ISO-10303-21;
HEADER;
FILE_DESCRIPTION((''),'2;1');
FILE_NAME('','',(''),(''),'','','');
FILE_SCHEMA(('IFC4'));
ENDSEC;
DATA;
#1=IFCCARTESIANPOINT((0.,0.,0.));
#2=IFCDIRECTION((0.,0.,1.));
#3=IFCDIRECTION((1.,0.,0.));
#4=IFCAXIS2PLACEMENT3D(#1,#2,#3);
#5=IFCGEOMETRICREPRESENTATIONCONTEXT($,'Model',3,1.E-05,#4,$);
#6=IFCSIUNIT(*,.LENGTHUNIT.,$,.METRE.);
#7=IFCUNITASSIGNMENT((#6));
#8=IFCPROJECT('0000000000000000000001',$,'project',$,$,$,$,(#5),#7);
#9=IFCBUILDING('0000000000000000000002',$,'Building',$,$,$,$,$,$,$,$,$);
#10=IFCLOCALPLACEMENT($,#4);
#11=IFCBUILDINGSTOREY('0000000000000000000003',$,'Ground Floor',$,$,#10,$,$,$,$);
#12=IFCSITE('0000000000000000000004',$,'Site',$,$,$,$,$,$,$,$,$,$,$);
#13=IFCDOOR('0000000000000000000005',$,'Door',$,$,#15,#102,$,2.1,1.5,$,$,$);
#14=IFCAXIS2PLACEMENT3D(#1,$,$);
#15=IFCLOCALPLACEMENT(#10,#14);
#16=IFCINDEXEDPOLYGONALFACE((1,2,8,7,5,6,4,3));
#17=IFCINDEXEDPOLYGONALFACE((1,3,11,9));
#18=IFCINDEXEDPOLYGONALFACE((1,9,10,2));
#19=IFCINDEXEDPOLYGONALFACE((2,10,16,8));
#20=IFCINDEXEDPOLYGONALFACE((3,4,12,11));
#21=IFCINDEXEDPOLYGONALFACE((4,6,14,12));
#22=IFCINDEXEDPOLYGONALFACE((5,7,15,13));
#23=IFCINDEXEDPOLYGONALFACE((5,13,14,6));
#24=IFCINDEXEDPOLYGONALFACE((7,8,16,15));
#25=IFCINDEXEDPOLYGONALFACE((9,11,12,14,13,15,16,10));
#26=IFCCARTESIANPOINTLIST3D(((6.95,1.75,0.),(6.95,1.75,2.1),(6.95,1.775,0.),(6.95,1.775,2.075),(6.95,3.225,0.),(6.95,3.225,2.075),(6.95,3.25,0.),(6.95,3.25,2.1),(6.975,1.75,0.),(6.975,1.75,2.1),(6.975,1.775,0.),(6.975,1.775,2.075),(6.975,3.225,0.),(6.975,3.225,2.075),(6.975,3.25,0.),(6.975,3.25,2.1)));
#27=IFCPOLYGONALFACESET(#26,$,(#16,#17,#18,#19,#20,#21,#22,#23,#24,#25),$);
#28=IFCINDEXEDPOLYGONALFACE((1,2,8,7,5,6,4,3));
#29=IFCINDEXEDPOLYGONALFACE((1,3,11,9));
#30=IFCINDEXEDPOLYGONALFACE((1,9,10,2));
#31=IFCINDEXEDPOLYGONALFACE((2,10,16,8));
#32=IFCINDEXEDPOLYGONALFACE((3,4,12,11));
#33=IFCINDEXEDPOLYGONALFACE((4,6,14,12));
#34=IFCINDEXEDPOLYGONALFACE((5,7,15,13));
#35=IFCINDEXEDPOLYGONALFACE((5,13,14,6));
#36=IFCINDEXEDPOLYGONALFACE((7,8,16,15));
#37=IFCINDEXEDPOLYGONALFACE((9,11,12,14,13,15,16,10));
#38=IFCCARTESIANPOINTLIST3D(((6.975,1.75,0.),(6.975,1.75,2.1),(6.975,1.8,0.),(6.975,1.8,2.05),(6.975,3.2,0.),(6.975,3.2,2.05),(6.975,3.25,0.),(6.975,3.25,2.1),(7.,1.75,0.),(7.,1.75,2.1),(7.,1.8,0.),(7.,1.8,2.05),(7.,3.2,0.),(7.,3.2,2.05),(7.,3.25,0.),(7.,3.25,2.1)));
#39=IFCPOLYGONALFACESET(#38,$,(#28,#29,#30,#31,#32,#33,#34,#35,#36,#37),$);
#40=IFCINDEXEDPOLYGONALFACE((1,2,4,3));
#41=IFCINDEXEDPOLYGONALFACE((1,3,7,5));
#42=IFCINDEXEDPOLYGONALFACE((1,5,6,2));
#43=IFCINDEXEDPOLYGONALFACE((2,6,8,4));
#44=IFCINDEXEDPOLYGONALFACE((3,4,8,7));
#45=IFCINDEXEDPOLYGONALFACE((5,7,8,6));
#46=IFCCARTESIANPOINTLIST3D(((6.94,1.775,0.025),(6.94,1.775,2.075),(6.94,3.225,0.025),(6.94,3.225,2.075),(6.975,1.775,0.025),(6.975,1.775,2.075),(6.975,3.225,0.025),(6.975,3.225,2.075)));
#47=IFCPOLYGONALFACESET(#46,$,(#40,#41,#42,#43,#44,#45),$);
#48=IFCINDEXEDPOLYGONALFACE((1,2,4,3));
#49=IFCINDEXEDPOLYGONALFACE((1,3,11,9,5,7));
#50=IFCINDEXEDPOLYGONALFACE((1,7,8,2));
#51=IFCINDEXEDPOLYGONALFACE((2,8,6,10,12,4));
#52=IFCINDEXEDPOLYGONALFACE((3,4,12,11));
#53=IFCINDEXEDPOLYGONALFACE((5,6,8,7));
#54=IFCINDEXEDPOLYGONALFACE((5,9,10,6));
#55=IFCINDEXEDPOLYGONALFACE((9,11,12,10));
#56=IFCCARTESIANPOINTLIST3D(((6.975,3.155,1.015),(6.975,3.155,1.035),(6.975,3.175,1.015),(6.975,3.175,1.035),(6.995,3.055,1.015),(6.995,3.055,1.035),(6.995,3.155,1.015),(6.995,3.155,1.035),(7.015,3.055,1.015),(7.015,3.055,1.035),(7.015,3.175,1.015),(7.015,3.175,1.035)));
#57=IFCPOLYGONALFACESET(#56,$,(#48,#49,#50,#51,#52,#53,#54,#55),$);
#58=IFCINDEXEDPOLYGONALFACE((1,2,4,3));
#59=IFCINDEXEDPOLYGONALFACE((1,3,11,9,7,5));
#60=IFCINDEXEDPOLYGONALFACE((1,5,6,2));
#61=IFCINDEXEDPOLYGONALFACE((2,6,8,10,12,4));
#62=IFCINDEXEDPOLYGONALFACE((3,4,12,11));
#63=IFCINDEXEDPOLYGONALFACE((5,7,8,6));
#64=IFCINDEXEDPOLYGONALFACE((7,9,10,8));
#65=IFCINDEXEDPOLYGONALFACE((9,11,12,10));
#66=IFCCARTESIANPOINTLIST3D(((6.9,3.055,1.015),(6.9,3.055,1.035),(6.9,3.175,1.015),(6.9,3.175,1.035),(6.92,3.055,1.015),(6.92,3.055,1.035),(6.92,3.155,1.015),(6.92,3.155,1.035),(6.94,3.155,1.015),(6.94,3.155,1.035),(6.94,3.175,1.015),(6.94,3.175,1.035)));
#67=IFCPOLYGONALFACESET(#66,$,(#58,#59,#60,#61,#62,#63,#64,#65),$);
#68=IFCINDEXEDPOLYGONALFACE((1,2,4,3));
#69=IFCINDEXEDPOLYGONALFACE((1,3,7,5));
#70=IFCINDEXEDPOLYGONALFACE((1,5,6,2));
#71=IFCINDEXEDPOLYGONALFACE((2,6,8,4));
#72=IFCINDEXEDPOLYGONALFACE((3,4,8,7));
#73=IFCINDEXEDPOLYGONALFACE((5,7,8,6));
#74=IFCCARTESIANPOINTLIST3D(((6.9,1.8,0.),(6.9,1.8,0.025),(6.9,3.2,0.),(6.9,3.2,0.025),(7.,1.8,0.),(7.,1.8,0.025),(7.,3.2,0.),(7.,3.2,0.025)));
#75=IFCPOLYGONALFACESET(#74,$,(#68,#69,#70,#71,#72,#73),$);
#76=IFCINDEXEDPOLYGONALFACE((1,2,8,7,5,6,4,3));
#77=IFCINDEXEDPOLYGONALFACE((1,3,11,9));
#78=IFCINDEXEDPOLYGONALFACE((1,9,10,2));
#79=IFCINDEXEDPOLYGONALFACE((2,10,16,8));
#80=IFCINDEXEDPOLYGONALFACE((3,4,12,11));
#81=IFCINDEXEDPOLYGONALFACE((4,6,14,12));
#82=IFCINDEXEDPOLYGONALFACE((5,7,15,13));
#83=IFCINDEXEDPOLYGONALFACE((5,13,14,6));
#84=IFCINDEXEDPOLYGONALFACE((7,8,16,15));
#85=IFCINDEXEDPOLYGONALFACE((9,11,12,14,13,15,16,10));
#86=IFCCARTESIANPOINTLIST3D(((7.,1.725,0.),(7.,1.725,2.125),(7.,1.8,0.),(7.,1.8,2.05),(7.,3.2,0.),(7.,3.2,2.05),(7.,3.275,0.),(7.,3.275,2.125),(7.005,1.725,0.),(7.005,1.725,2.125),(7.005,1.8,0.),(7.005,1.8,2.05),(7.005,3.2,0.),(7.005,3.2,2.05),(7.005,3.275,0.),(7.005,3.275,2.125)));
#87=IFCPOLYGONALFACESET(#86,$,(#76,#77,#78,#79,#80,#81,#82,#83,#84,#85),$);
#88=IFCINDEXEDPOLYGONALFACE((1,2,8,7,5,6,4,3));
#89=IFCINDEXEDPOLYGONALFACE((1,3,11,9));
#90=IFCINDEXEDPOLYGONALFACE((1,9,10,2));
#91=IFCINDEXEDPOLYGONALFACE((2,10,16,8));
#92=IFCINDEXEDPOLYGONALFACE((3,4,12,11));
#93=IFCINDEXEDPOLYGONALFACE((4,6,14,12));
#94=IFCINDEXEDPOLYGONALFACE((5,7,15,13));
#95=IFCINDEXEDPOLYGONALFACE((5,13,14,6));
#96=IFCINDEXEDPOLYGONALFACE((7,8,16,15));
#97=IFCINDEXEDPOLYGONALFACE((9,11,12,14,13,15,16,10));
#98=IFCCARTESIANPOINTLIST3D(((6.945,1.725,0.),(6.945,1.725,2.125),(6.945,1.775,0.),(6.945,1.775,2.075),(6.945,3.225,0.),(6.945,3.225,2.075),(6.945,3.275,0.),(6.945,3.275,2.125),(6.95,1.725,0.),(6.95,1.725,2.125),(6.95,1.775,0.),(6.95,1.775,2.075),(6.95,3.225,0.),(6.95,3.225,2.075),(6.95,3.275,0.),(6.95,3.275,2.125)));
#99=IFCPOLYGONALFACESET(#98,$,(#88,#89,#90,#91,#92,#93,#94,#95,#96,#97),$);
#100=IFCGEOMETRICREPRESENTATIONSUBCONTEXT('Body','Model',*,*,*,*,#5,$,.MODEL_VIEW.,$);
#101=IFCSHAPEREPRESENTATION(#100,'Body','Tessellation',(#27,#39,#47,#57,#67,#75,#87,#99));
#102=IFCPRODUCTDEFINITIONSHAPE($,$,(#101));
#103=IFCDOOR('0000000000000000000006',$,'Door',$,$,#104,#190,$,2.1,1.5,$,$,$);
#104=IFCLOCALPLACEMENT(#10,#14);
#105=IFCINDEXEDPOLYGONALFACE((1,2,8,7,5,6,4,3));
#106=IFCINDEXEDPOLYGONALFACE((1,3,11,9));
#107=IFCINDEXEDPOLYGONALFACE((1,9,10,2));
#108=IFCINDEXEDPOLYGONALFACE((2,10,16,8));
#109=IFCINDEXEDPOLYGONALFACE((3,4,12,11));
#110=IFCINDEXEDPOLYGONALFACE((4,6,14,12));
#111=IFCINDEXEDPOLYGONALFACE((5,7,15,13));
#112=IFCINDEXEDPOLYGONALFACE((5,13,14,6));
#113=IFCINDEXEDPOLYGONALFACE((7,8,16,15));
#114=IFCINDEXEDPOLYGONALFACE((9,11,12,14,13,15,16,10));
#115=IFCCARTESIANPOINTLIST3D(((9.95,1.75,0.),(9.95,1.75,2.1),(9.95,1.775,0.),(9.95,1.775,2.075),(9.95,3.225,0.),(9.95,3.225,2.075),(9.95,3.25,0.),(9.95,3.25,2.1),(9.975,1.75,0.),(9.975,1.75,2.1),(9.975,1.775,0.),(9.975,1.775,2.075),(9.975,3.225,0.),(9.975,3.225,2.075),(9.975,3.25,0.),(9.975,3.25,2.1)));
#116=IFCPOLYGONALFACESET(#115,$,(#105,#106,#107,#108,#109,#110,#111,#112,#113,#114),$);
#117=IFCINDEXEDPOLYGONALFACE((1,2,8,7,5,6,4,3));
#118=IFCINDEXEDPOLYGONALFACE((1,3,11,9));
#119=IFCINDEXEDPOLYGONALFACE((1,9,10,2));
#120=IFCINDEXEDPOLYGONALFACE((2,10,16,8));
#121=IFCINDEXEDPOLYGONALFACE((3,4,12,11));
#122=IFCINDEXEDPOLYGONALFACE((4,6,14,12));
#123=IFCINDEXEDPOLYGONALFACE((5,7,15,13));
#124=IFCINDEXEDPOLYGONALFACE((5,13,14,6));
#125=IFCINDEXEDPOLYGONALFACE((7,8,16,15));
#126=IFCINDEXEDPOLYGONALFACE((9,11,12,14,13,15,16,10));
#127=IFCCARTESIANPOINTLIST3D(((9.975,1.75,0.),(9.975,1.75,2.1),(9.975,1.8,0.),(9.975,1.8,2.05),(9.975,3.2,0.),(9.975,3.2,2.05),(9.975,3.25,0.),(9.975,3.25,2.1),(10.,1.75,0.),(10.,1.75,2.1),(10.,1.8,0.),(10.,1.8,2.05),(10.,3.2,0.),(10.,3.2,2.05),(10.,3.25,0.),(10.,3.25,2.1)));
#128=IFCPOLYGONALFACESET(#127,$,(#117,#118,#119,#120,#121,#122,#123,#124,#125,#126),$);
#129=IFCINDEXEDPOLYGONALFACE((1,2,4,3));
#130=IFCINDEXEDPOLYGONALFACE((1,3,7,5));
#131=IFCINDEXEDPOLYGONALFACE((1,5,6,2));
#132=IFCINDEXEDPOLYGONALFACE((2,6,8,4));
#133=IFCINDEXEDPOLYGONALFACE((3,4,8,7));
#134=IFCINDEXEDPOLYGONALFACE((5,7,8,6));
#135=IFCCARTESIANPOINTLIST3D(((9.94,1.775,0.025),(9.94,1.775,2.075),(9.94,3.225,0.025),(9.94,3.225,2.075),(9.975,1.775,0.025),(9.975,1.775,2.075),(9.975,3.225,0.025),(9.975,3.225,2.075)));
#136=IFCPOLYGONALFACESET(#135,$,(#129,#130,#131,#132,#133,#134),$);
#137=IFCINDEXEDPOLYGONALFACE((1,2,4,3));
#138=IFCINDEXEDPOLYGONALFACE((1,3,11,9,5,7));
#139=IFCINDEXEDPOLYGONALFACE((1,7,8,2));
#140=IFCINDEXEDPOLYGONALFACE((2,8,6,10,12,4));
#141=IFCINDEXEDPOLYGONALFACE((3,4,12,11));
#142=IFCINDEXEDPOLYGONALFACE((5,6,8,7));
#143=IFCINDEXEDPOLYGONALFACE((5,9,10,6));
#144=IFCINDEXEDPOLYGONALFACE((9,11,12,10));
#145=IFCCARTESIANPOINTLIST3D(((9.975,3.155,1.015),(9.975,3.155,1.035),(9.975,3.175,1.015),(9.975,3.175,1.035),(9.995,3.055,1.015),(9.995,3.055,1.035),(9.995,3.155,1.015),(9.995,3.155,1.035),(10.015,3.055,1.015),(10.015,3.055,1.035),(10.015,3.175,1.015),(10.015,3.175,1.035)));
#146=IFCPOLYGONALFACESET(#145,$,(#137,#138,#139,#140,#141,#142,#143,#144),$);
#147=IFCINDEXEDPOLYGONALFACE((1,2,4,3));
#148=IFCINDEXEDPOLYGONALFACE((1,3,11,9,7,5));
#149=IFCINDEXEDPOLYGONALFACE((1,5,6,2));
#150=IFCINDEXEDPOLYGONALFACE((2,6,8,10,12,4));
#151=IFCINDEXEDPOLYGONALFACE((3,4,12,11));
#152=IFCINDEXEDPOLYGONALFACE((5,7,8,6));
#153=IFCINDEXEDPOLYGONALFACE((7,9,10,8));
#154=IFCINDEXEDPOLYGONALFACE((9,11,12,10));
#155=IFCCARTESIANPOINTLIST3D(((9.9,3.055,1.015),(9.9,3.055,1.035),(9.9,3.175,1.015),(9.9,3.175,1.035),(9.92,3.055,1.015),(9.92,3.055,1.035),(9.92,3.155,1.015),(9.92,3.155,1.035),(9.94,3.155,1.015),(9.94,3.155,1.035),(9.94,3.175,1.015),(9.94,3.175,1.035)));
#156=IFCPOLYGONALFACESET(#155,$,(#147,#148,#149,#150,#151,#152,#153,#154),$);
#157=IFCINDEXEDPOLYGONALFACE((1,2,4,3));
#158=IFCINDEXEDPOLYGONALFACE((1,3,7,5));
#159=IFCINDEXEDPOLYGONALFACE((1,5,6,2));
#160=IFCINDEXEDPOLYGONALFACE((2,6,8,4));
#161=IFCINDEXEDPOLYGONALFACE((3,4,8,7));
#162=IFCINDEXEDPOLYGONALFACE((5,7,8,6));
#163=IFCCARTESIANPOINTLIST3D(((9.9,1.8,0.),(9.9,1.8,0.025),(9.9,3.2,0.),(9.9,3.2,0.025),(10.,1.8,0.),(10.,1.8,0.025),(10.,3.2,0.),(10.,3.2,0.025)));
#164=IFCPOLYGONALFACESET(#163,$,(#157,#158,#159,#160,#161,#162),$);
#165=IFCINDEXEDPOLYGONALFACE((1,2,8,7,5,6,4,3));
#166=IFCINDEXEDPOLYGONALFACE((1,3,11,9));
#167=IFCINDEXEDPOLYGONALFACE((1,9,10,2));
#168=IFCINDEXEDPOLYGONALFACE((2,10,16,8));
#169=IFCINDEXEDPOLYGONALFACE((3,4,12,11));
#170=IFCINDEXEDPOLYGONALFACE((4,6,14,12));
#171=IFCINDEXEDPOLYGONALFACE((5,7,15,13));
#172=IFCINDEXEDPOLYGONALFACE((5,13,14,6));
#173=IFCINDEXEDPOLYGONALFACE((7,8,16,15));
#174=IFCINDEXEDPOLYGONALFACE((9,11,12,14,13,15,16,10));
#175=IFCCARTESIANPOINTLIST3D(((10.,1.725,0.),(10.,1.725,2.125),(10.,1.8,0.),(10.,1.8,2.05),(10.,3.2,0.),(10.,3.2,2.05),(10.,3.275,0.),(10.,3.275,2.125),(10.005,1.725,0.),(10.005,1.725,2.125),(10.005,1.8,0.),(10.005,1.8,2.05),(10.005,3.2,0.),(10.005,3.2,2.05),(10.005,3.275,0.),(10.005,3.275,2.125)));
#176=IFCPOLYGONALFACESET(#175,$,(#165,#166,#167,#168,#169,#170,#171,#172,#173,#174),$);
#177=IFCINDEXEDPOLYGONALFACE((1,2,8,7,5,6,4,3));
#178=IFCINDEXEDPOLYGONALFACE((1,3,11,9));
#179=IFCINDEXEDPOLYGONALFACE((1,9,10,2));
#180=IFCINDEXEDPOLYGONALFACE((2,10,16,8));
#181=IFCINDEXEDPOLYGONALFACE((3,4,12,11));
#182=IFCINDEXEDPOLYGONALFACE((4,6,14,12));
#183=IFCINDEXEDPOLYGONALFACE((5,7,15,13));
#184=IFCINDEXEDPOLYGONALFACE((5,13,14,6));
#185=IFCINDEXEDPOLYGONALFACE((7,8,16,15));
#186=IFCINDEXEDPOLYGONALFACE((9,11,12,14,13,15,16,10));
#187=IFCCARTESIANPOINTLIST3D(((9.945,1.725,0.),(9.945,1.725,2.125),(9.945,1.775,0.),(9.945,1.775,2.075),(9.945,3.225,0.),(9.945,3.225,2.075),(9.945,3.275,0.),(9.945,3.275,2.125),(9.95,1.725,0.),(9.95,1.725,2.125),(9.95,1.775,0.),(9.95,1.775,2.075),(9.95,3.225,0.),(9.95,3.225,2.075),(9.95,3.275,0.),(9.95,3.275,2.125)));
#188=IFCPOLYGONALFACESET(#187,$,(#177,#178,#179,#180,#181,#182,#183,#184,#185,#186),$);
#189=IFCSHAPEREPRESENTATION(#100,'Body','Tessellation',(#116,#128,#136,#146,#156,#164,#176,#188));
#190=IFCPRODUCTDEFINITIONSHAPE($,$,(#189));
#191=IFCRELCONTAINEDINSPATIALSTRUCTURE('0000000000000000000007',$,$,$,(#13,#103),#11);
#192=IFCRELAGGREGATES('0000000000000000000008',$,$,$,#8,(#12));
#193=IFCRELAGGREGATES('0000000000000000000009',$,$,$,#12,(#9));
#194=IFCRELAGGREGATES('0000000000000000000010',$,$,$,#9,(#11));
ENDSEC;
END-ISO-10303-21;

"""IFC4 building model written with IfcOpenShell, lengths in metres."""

from ifc_helpers import new_model, si_unit, frame, origin_with_axes, place, context, subcontext, project, spatial, line, indexed_curve, outline, extrude, element, save


model = new_model("IFC4")

# Units and contexts
model_context = context("Model", 3, precision=1e-05, world=origin_with_axes())
body_context = subcontext(model_context, "Body", "Model", "MODEL_VIEW")
ifc_project = project(units=[si_unit("LENGTHUNIT", "METRE")], contexts=[model_context])

# Site, building, storey
site = spatial("IfcSite", under=ifc_project, Name="Site")
building = spatial("IfcBuilding", under=site, Name="Building")
storey_placement = place(None, origin_with_axes())
storey = spatial("IfcBuildingStorey", under=building, at=storey_placement, Name="Ground Floor")

# Doors
door_1_placement = place(storey_placement, frame((7.0, 1.75, 0.0), z_axis=(0.0, 0.0, 1.0), x_axis=(0.0, 1.0, 0.0)))
element("IfcDoor", 1, at=door_1_placement, inside=storey, Name="Door", OverallHeight=2.1, OverallWidth=1.5, context=body_context, shape_type="SweptSolid", body=[
    extrude(outline(indexed_curve([(0.0, 0.0), (0.0, 2.1), (1.5, 2.1), (1.5, 0.0), (1.475, 0.0), (1.475, 2.075), (0.025, 2.075), (0.025, 0.0)], segments=[line(1, 2, 3, 4, 5, 6, 7, 8, 1)])), frame((0.0, 0.025, 0.0), z_axis=(0.0, -1.0, 0.0), x_axis=(1.0, 0.0, 0.0)), (0.0, 0.0, -1.0), 0.025),
    extrude(outline(indexed_curve([(0.0, 0.0), (0.0, 2.1), (1.5, 2.1), (1.5, 0.0), (1.45, 0.0), (1.45, 2.05), (0.05, 2.05), (0.05, 0.0)], segments=[line(1, 2, 3, 4, 5, 6, 7, 8, 1)])), frame((0.0, 0.0, 0.0), z_axis=(0.0, -1.0, 0.0), x_axis=(1.0, 0.0, 0.0)), (0.0, 0.0, -1.0), 0.025),
    extrude(outline(indexed_curve([(0.0, 0.0), (1.45, 0.0), (1.45, 0.035), (0.0, 0.035)], segments=[line(1, 2, 3, 4, 1)])), frame((0.025, 0.025, 0.025), z_axis=(0.0, 0.0, 1.0), x_axis=(1.0, 0.0, 0.0)), (0.0, 0.0, 1.0), 2.05),
    extrude(outline(indexed_curve([(0.0, 0.0), (0.0, -0.04), (-0.12, -0.04), (-0.12, -0.02), (-0.02, -0.02), (-0.02, 0.0)], segments=[line(1, 2, 3, 4, 5, 6, 1)])), frame((1.425, 0.025, 1.015), z_axis=(0.0, 0.0, 1.0), x_axis=(1.0, 0.0, 0.0)), (0.0, 0.0, 1.0), 0.02),
    extrude(outline(indexed_curve([(0.0, 0.0), (0.0, 0.04), (-0.12, 0.04), (-0.12, 0.02), (-0.02, 0.02), (-0.02, 0.0)], segments=[line(1, 2, 3, 4, 5, 6, 1)])), frame((1.425, 0.06, 1.015), z_axis=(0.0, 0.0, 1.0), x_axis=(1.0, 0.0, 0.0)), (0.0, 0.0, 1.0), 0.02),
    extrude(outline(indexed_curve([(0.0, 0.0), (1.4, 0.0), (1.4, 0.1), (0.0, 0.1)], segments=[line(1, 2, 3, 4, 1)])), frame((0.05, 0.0, 0.0), z_axis=(0.0, 0.0, 1.0), x_axis=(1.0, 0.0, 0.0)), (0.0, 0.0, 1.0), 0.025),
    extrude(outline(indexed_curve([(0.0, 0.0), (0.0, 2.125), (1.55, 2.125), (1.55, 0.0), (1.475, 0.0), (1.475, 2.05), (0.075, 2.05), (0.075, 0.0)], segments=[line(1, 2, 3, 4, 5, 6, 7, 8, 1)])), frame((-0.025, -0.005, 0.0), z_axis=(0.0, -1.0, 0.0), x_axis=(1.0, 0.0, 0.0)), (0.0, 0.0, -1.0), 0.005),
    extrude(outline(indexed_curve([(0.0, 0.0), (0.0, 2.125), (1.55, 2.125), (1.55, 0.0), (1.5, 0.0), (1.5, 2.075), (0.05, 2.075), (0.05, 0.0)], segments=[line(1, 2, 3, 4, 5, 6, 7, 8, 1)])), frame((-0.025, 0.05, 0.0), z_axis=(0.0, -1.0, 0.0), x_axis=(1.0, 0.0, 0.0)), (0.0, 0.0, -1.0), 0.005),
])
door_2_placement = place(storey_placement, frame((10.0, 1.75, 0.0), z_axis=(0.0, 0.0, 1.0), x_axis=(0.0, 1.0, 0.0)))
element("IfcDoor", 2, at=door_2_placement, inside=storey, Name="Door", OverallHeight=2.1, OverallWidth=1.5, context=body_context, shape_type="SweptSolid", body=[
    extrude(outline(indexed_curve([(0.0, 0.0), (0.0, 2.1), (1.5, 2.1), (1.5, 0.0), (1.475, 0.0), (1.475, 2.075), (0.025, 2.075), (0.025, 0.0)], segments=[line(1, 2, 3, 4, 5, 6, 7, 8, 1)])), frame((0.0, 0.025, 0.0), z_axis=(0.0, -1.0, 0.0), x_axis=(1.0, 0.0, 0.0)), (0.0, 0.0, -1.0), 0.025),
    extrude(outline(indexed_curve([(0.0, 0.0), (0.0, 2.1), (1.5, 2.1), (1.5, 0.0), (1.45, 0.0), (1.45, 2.05), (0.05, 2.05), (0.05, 0.0)], segments=[line(1, 2, 3, 4, 5, 6, 7, 8, 1)])), frame((0.0, 0.0, 0.0), z_axis=(0.0, -1.0, 0.0), x_axis=(1.0, 0.0, 0.0)), (0.0, 0.0, -1.0), 0.025),
    extrude(outline(indexed_curve([(0.0, 0.0), (1.45, 0.0), (1.45, 0.035), (0.0, 0.035)], segments=[line(1, 2, 3, 4, 1)])), frame((0.025, 0.025, 0.025), z_axis=(0.0, 0.0, 1.0), x_axis=(1.0, 0.0, 0.0)), (0.0, 0.0, 1.0), 2.05),
    extrude(outline(indexed_curve([(0.0, 0.0), (0.0, -0.04), (-0.12, -0.04), (-0.12, -0.02), (-0.02, -0.02), (-0.02, 0.0)], segments=[line(1, 2, 3, 4, 5, 6, 1)])), frame((1.425, 0.025, 1.015), z_axis=(0.0, 0.0, 1.0), x_axis=(1.0, 0.0, 0.0)), (0.0, 0.0, 1.0), 0.02),
    extrude(outline(indexed_curve([(0.0, 0.0), (0.0, 0.04), (-0.12, 0.04), (-0.12, 0.02), (-0.02, 0.02), (-0.02, 0.0)], segments=[line(1, 2, 3, 4, 5, 6, 1)])), frame((1.425, 0.06, 1.015), z_axis=(0.0, 0.0, 1.0), x_axis=(1.0, 0.0, 0.0)), (0.0, 0.0, 1.0), 0.02),
    extrude(outline(indexed_curve([(0.0, 0.0), (1.4, 0.0), (1.4, 0.1), (0.0, 0.1)], segments=[line(1, 2, 3, 4, 1)])), frame((0.05, 0.0, 0.0), z_axis=(0.0, 0.0, 1.0), x_axis=(1.0, 0.0, 0.0)), (0.0, 0.0, 1.0), 0.025),
    extrude(outline(indexed_curve([(0.0, 0.0), (0.0, 2.125), (1.55, 2.125), (1.55, 0.0), (1.475, 0.0), (1.475, 2.05), (0.075, 2.05), (0.075, 0.0)], segments=[line(1, 2, 3, 4, 5, 6, 7, 8, 1)])), frame((-0.025, -0.005, 0.0), z_axis=(0.0, -1.0, 0.0), x_axis=(1.0, 0.0, 0.0)), (0.0, 0.0, -1.0), 0.005),
    extrude(outline(indexed_curve([(0.0, 0.0), (0.0, 2.125), (1.55, 2.125), (1.55, 0.0), (1.5, 0.0), (1.5, 2.075), (0.05, 2.075), (0.05, 0.0)], segments=[line(1, 2, 3, 4, 5, 6, 7, 8, 1)])), frame((-0.025, 0.05, 0.0), z_axis=(0.0, -1.0, 0.0), x_axis=(1.0, 0.0, 0.0)), (0.0, 0.0, -1.0), 0.005),
])

save(model, "model.ifc")
